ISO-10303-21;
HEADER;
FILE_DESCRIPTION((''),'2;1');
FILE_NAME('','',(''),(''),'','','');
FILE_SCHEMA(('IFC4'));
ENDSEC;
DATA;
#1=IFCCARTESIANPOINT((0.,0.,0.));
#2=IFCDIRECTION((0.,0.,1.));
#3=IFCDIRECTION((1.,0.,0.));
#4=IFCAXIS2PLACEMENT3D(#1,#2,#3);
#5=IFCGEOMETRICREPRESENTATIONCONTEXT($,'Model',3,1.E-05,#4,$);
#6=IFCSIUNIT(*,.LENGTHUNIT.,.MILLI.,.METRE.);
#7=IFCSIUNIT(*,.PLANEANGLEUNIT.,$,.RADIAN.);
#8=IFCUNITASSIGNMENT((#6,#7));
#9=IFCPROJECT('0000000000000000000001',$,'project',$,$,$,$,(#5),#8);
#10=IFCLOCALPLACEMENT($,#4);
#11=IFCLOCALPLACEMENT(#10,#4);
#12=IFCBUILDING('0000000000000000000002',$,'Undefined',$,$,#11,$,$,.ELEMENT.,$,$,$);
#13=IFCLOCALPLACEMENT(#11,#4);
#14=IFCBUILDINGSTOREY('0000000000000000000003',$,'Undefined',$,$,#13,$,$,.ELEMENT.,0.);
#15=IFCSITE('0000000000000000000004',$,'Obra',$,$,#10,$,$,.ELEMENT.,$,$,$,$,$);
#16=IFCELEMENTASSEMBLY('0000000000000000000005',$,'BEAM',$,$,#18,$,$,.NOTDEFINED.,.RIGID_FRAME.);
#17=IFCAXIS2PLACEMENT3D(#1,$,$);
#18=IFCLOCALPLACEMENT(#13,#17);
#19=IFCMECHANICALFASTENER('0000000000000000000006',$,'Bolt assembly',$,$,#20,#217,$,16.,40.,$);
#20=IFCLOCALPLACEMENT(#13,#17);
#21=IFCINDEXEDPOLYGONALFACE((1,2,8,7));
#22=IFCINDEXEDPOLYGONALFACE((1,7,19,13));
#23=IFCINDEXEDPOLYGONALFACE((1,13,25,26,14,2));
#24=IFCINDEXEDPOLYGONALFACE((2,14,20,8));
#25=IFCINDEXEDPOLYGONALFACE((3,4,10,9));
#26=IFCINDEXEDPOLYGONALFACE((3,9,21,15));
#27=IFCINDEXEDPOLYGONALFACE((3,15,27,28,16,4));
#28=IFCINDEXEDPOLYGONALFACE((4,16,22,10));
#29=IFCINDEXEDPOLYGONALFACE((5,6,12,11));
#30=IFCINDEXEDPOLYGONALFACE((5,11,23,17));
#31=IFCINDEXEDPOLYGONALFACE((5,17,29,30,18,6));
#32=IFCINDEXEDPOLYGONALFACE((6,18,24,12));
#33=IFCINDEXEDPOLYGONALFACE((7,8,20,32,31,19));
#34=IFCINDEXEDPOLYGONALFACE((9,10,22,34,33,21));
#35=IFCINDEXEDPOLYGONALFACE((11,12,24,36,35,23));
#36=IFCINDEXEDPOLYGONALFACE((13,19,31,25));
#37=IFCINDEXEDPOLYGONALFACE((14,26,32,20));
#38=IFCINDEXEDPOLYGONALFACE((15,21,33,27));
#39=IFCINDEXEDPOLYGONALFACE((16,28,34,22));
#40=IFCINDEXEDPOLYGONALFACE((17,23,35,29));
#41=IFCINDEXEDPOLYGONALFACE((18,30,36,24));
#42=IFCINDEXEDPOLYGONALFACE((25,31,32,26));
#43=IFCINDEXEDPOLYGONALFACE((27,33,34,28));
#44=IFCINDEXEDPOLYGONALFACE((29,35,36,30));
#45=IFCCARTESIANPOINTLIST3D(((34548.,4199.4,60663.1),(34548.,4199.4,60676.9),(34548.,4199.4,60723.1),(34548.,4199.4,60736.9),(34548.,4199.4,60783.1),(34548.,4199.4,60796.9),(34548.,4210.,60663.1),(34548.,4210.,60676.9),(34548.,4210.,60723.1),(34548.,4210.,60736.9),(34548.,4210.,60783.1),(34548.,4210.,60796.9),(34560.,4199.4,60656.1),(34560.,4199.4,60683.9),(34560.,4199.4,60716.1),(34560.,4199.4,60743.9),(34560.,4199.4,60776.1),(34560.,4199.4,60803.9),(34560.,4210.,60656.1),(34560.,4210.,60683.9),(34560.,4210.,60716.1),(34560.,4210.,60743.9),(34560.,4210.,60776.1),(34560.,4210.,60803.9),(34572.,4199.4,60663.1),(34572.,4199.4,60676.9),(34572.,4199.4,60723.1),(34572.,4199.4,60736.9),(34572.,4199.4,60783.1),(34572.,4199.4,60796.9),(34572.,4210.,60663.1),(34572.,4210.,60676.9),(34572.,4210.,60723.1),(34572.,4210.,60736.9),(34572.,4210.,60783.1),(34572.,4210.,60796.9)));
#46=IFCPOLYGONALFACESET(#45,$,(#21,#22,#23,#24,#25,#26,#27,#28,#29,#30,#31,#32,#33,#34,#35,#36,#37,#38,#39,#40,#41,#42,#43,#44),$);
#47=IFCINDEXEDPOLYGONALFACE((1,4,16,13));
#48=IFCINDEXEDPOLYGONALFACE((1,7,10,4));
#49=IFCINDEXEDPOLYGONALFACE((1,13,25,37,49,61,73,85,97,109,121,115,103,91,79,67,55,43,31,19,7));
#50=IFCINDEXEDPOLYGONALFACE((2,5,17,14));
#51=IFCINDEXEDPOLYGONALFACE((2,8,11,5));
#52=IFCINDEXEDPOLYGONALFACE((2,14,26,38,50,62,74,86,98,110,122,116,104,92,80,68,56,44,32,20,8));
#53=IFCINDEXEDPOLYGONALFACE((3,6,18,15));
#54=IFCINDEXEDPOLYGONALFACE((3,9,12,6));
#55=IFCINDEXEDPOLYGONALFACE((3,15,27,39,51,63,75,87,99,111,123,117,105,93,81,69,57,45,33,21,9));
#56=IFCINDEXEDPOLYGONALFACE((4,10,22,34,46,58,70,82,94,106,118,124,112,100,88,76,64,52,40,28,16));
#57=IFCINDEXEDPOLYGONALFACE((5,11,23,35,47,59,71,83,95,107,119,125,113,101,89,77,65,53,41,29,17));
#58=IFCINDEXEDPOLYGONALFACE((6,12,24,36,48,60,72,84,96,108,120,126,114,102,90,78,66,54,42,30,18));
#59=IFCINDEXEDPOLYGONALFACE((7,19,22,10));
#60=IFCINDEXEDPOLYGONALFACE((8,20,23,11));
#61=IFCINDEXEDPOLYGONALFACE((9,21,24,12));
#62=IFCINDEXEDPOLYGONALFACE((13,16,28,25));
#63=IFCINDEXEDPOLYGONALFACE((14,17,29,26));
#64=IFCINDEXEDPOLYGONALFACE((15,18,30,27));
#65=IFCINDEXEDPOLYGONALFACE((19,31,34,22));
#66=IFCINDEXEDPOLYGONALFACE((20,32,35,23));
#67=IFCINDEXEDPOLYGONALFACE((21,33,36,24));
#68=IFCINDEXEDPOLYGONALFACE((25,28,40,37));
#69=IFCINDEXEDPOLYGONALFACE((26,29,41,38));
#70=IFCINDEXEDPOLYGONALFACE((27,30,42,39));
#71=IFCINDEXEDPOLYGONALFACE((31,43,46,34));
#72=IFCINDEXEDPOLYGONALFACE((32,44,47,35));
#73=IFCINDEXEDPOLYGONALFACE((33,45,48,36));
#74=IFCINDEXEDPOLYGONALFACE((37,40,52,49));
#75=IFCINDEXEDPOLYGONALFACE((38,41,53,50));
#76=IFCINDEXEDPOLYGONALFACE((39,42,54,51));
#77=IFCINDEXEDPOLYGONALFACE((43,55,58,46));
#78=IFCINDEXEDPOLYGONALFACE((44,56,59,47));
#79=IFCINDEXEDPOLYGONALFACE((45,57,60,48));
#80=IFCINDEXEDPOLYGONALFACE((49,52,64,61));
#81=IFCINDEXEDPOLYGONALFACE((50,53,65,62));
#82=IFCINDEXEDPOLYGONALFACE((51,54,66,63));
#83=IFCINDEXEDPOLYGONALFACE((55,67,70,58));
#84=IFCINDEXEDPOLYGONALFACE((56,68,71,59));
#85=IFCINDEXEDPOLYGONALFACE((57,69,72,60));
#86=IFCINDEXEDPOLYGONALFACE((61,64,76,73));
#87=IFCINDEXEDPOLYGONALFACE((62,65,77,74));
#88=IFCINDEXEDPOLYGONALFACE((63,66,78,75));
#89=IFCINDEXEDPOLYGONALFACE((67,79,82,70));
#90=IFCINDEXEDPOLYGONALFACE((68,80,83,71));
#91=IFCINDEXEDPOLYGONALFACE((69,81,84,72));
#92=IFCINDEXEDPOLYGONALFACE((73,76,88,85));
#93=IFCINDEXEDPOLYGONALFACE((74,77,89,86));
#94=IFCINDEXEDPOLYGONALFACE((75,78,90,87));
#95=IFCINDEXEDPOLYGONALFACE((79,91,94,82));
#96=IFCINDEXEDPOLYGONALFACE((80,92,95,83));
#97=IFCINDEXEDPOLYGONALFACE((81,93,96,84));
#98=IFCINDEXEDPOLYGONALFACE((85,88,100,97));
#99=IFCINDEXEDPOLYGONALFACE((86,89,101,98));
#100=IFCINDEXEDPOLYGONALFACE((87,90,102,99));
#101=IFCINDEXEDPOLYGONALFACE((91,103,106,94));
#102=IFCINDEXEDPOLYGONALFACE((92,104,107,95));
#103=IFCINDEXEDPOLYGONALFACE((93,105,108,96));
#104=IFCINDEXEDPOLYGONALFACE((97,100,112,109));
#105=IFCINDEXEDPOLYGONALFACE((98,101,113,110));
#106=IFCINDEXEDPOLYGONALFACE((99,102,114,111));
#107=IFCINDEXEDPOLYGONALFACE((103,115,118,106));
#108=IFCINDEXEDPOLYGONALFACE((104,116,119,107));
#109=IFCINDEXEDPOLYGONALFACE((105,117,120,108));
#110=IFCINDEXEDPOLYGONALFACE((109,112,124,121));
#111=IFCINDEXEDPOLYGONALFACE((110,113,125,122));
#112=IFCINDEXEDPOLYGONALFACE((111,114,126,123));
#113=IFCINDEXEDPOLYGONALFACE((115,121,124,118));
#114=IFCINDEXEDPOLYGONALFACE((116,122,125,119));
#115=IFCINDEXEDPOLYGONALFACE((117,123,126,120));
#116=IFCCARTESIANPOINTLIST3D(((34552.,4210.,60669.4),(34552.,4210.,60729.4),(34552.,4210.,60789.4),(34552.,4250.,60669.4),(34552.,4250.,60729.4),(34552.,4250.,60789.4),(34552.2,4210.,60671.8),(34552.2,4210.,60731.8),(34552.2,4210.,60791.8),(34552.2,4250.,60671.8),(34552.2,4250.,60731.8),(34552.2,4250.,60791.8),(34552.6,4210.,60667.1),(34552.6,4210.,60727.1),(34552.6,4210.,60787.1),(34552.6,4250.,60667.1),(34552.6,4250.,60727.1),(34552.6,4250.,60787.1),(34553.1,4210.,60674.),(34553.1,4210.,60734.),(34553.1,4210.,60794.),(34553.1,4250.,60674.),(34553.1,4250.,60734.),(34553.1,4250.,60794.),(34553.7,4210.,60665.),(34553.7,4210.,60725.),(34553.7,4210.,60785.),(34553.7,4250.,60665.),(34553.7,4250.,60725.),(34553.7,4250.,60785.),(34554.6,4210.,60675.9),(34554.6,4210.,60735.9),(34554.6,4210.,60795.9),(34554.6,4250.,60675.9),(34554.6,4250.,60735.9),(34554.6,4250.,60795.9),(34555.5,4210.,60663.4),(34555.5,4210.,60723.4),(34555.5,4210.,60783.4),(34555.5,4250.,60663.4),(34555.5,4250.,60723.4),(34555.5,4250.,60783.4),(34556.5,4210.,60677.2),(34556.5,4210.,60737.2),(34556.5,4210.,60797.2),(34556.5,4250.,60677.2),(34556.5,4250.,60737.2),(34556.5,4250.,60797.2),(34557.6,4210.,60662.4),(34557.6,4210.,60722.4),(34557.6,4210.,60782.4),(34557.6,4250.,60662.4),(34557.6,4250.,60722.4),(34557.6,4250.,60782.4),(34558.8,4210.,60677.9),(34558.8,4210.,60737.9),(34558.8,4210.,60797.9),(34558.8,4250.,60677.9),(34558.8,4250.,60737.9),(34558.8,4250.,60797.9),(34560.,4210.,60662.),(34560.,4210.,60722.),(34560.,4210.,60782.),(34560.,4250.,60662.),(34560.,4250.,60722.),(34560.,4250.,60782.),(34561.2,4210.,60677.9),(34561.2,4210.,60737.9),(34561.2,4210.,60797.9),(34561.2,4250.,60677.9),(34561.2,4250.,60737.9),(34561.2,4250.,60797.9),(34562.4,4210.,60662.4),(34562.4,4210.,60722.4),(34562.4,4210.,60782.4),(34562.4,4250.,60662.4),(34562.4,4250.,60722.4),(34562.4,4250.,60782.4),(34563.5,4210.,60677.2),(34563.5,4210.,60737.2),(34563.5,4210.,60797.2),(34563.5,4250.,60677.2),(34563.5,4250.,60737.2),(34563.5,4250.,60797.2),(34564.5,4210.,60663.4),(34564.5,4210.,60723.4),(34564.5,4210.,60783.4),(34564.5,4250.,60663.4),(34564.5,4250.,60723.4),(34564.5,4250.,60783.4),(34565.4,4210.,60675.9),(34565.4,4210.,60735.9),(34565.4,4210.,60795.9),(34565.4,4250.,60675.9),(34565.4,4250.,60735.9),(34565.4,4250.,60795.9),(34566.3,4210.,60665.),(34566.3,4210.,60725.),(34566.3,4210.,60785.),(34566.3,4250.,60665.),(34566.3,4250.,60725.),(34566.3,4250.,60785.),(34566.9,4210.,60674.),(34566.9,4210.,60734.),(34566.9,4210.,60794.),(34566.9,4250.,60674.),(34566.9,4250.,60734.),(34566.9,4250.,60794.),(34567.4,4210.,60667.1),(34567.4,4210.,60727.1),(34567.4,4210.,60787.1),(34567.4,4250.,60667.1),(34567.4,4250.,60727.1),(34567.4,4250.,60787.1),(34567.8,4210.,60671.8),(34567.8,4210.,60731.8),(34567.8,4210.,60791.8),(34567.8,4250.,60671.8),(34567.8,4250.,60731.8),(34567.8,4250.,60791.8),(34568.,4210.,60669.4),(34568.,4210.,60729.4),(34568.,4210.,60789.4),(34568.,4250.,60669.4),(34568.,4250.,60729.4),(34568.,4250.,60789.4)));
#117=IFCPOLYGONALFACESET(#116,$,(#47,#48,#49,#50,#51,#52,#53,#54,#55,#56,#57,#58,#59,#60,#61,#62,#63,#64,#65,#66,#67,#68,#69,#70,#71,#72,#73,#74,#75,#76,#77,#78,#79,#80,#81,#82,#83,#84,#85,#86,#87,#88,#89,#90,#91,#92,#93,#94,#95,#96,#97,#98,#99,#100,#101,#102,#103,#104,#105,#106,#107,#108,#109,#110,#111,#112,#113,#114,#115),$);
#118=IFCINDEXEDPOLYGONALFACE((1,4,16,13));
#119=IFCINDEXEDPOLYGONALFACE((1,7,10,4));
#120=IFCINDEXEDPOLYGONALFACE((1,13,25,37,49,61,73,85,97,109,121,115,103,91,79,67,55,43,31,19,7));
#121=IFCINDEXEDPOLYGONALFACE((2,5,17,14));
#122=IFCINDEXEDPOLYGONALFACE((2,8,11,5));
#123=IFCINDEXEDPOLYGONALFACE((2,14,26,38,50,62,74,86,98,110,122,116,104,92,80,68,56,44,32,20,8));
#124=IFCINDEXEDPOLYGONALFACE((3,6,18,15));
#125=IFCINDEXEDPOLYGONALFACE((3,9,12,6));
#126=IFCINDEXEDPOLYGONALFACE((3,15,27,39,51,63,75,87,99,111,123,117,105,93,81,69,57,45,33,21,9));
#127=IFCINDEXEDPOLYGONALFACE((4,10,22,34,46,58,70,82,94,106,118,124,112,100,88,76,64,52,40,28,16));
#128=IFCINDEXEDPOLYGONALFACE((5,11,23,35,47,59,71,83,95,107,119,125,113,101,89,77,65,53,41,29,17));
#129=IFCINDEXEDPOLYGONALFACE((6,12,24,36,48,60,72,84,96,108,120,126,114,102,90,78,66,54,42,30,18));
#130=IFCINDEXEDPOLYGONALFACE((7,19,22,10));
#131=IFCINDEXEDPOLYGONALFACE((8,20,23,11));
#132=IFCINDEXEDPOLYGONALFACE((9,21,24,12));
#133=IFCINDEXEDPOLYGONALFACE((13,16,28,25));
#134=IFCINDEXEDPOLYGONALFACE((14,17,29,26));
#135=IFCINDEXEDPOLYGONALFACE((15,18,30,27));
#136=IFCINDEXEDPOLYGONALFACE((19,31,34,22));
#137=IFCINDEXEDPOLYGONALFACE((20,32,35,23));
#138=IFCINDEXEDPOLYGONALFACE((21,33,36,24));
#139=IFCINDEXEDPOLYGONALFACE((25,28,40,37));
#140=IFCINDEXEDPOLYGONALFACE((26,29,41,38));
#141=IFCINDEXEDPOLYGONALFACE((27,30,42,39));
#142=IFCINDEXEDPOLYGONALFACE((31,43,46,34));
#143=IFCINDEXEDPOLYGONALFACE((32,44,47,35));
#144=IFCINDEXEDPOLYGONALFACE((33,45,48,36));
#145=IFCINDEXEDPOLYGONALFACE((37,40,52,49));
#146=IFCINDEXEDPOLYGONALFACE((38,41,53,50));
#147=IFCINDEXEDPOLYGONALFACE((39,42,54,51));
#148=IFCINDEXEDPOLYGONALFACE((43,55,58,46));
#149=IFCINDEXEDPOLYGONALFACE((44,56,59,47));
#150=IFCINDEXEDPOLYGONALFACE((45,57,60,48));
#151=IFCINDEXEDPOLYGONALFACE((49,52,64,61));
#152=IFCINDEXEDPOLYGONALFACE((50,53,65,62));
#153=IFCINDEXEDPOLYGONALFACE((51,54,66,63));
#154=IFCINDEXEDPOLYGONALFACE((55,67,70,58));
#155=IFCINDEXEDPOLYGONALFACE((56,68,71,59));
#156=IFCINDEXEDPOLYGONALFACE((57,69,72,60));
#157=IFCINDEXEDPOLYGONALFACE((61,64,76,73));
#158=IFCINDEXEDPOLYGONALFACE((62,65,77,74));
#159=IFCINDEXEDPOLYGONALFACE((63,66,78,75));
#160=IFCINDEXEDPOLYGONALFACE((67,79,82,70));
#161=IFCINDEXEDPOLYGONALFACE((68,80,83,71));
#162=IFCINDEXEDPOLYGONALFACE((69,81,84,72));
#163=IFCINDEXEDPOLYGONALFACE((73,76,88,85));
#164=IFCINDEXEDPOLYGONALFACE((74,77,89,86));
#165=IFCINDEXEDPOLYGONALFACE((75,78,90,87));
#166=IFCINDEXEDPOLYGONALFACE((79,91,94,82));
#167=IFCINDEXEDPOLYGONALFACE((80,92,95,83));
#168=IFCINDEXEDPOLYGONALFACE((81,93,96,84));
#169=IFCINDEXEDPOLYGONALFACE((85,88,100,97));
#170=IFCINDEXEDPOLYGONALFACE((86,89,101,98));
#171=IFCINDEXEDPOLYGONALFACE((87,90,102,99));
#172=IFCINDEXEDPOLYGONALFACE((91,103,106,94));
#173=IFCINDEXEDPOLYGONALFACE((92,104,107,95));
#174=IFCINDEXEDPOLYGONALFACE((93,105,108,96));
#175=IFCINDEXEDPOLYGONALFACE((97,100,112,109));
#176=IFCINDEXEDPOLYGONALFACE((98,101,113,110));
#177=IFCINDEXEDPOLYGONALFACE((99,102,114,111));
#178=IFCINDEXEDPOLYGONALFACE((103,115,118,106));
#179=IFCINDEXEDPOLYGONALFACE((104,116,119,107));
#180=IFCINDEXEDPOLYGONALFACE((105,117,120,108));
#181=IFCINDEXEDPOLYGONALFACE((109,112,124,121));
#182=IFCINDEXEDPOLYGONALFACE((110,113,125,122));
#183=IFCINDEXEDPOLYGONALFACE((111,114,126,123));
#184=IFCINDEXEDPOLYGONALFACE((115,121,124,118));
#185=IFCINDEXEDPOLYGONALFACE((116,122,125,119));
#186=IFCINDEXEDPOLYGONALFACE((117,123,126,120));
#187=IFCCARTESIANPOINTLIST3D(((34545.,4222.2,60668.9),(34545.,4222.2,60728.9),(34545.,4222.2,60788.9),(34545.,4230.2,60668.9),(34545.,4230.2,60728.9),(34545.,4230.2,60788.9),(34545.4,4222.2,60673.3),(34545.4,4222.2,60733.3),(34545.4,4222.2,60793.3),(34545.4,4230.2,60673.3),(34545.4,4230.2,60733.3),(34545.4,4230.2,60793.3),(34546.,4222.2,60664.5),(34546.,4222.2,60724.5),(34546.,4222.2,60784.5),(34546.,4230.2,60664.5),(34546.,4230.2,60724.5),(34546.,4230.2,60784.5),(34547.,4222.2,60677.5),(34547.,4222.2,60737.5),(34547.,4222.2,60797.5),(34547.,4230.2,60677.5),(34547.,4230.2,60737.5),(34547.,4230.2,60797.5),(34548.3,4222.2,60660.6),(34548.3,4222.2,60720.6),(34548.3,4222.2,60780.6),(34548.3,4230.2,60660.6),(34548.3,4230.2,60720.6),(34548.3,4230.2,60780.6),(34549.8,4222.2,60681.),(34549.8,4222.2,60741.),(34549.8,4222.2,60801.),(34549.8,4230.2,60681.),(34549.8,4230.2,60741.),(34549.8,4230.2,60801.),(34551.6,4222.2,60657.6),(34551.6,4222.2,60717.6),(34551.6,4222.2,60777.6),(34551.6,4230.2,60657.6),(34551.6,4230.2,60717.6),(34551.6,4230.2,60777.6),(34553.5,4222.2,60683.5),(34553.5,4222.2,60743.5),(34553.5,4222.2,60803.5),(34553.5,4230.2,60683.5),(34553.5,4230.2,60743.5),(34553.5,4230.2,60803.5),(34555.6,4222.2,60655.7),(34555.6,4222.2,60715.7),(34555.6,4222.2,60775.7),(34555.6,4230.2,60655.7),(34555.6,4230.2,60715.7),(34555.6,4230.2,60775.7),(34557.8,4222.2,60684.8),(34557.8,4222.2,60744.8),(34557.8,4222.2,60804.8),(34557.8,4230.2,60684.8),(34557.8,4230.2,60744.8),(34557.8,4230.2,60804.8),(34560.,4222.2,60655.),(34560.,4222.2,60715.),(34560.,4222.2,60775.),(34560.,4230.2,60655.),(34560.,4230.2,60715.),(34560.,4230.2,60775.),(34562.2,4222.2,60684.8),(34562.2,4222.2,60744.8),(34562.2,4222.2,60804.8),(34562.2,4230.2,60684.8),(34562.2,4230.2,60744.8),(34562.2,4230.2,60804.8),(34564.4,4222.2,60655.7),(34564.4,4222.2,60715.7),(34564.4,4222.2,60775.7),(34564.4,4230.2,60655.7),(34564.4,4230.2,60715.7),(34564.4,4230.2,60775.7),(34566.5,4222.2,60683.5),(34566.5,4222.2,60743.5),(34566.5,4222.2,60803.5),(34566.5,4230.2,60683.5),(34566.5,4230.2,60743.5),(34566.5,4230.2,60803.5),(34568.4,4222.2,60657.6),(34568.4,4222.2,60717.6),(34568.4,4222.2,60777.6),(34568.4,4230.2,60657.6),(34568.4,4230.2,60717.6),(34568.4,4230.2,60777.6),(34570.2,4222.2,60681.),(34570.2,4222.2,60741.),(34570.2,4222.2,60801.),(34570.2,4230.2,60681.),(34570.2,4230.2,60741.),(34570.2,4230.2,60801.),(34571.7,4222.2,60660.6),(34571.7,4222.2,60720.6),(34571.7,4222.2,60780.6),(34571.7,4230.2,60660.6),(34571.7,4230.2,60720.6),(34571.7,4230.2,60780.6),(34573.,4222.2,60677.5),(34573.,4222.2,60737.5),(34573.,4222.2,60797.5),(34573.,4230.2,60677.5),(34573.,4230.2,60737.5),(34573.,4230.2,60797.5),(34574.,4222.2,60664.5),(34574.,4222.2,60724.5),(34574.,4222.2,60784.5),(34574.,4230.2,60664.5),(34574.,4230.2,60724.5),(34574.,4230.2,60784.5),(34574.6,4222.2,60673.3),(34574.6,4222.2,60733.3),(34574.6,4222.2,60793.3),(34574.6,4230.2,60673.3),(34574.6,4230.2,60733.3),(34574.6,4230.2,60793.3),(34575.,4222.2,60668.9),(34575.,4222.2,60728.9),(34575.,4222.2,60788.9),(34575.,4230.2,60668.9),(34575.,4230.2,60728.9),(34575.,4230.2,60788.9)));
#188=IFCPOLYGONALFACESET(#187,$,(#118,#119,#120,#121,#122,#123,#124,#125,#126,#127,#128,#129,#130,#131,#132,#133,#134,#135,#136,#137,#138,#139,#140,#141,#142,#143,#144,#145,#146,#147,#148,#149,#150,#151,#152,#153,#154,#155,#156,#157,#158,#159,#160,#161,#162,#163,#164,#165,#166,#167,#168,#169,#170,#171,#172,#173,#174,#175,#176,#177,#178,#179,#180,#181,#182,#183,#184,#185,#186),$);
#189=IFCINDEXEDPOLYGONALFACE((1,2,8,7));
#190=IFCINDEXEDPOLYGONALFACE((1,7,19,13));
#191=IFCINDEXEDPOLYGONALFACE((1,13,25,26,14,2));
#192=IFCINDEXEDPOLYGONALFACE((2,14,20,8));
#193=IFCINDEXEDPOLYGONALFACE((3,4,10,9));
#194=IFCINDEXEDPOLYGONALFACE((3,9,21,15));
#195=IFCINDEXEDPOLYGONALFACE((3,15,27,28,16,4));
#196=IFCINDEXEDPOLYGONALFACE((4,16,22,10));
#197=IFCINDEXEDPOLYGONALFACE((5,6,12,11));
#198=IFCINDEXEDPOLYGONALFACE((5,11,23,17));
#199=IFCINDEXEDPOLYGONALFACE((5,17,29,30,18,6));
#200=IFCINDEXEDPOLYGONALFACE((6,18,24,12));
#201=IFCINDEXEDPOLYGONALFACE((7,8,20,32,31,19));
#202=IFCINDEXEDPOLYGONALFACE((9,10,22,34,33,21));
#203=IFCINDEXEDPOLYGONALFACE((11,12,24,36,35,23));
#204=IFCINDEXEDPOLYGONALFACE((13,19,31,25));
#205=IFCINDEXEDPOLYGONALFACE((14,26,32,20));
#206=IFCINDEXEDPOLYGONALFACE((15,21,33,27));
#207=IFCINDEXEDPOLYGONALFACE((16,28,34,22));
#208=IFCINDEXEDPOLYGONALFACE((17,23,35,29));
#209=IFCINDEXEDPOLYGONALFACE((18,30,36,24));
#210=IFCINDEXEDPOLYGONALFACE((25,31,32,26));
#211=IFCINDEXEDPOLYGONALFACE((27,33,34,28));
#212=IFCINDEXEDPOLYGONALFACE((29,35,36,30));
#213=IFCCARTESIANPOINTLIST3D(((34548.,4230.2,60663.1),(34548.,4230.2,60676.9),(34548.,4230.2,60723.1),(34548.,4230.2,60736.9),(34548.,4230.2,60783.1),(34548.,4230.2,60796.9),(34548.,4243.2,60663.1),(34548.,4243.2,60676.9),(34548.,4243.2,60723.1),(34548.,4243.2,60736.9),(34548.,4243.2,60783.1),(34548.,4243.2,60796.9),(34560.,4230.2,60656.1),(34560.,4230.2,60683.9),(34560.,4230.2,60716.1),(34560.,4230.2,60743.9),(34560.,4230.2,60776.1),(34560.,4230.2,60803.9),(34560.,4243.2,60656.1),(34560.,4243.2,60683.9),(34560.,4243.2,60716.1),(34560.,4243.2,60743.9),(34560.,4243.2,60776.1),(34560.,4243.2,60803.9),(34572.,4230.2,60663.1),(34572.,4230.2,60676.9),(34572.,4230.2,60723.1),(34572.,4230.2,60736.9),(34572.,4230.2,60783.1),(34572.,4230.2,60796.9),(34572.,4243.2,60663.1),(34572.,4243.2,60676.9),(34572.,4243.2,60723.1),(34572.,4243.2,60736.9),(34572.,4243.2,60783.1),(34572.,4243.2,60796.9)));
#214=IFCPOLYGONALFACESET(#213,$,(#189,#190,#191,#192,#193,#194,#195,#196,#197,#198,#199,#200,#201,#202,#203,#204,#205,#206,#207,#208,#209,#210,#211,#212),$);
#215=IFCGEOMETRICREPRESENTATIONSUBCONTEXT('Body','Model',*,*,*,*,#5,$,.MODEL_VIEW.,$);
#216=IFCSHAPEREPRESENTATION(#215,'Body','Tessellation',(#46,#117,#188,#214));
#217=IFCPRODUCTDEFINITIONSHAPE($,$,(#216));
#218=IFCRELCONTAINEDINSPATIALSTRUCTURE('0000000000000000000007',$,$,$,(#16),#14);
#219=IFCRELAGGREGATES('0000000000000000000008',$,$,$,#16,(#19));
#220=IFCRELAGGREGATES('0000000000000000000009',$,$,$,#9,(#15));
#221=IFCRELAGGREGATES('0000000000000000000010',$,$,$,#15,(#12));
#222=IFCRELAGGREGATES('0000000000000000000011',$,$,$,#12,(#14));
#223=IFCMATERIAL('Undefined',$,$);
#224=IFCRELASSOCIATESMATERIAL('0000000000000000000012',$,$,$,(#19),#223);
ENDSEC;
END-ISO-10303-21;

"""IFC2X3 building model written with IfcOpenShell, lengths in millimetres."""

from ifc_helpers import new_model, si_unit, frame, origin_with_axes, origin_2d_with_axis, place, context, subcontext, project, spatial, polyline, circle, outline, extrude, source, transform, mapped, material, element, aggregate, save


model = new_model("IFC2X3")

# Units and contexts
model_context = context("Model", 3, precision=1e-05, world=origin_with_axes())
body_context = subcontext(model_context, "Body", "Model", "MODEL_VIEW")
ifc_project = project(units=[si_unit("LENGTHUNIT", "METRE", prefix="MILLI"), si_unit("PLANEANGLEUNIT", "RADIAN")], contexts=[model_context])

# Site, building, storey
site_placement = place(None, origin_with_axes())
site = spatial("IfcSite", under=ifc_project, at=site_placement, Name="Obra", CompositionType="ELEMENT")
building_placement = place(site_placement, origin_with_axes())
building = spatial("IfcBuilding", under=site, at=building_placement, Name="Undefined", CompositionType="ELEMENT")
storey_placement = place(building_placement, origin_with_axes())
storey = spatial("IfcBuildingStorey", under=building, at=storey_placement, Name="Undefined", CompositionType="ELEMENT", Elevation=0.0)

# Shared definitions
ifc_material_1 = material(Name="Undefined")

# Element assembly, mechanical fastener
shared_shape_1 = source(origin_with_axes(), body_context, "Body", "SweptSolid", [
    extrude(outline(polyline([(13.9, 0.0), (6.9, 12.0), (-6.9, 12.0), (-13.9, 0.0), (-6.9, -12.0), (6.9, -12.0), (13.9, 0.0)])), frame((0.0, -19.7, 0.0), z_axis=(0.0, 1.0, 0.0), x_axis=(1.0, 0.0, 0.0)), (0.0, 0.0, 1.0), 10.6),
    extrude(circle(Radius=8.0, at=origin_2d_with_axis()), frame((0.0, -9.1, 0.0), z_axis=(0.0, 1.0, 0.0), x_axis=(1.0, 0.0, 0.0)), (0.0, 0.0, 1.0), 40.0),
    extrude(circle(Radius=15.0, at=origin_2d_with_axis()), frame((0.0, 3.1, 0.0), z_axis=(0.0, 1.0, 0.0), x_axis=(1.0, 0.0, 0.0)), (0.0, 0.0, 1.0), 8.0),
    extrude(outline(polyline([(13.9, 0.0), (6.9, 12.0), (-6.9, 12.0), (-13.9, 0.0), (-6.9, -12.0), (6.9, -12.0), (13.9, 0.0)])), frame((0.0, 11.1, 0.0), z_axis=(0.0, 1.0, 0.0), x_axis=(1.0, 0.0, 0.0)), (0.0, 0.0, 1.0), 13.0),
])
assembly_1_placement = place(storey_placement, origin_with_axes())
assembly_1 = element("IfcElementAssembly", 1, at=assembly_1_placement, inside=storey, Name="BEAM", AssemblyPlace="NOTDEFINED", PredefinedType="RIGID_FRAME")
mechanical_fastener_1_placement = place(assembly_1_placement, frame((34510.0, 4219.1, 60850.0), z_axis=(1.0, 0.0, 0.0), x_axis=(0.0, 0.0, -1.0)))
mechanical_fastener_1 = element("IfcMechanicalFastener", 2, at=mechanical_fastener_1_placement, material=ifc_material_1, Name="Bolt assembly", NominalDiameter=16.0, NominalLength=40.0, context=body_context, shape_type="MappedRepresentation", body=[
    mapped(shared_shape_1, transform((60.0, 0.0, 50.0))),
    mapped(shared_shape_1, transform((120.0, 0.0, 50.0))),
    mapped(shared_shape_1, transform((180.0, 0.0, 50.0))),
])
aggregate(assembly_1, [mechanical_fastener_1])

save(model, "model.ifc")
